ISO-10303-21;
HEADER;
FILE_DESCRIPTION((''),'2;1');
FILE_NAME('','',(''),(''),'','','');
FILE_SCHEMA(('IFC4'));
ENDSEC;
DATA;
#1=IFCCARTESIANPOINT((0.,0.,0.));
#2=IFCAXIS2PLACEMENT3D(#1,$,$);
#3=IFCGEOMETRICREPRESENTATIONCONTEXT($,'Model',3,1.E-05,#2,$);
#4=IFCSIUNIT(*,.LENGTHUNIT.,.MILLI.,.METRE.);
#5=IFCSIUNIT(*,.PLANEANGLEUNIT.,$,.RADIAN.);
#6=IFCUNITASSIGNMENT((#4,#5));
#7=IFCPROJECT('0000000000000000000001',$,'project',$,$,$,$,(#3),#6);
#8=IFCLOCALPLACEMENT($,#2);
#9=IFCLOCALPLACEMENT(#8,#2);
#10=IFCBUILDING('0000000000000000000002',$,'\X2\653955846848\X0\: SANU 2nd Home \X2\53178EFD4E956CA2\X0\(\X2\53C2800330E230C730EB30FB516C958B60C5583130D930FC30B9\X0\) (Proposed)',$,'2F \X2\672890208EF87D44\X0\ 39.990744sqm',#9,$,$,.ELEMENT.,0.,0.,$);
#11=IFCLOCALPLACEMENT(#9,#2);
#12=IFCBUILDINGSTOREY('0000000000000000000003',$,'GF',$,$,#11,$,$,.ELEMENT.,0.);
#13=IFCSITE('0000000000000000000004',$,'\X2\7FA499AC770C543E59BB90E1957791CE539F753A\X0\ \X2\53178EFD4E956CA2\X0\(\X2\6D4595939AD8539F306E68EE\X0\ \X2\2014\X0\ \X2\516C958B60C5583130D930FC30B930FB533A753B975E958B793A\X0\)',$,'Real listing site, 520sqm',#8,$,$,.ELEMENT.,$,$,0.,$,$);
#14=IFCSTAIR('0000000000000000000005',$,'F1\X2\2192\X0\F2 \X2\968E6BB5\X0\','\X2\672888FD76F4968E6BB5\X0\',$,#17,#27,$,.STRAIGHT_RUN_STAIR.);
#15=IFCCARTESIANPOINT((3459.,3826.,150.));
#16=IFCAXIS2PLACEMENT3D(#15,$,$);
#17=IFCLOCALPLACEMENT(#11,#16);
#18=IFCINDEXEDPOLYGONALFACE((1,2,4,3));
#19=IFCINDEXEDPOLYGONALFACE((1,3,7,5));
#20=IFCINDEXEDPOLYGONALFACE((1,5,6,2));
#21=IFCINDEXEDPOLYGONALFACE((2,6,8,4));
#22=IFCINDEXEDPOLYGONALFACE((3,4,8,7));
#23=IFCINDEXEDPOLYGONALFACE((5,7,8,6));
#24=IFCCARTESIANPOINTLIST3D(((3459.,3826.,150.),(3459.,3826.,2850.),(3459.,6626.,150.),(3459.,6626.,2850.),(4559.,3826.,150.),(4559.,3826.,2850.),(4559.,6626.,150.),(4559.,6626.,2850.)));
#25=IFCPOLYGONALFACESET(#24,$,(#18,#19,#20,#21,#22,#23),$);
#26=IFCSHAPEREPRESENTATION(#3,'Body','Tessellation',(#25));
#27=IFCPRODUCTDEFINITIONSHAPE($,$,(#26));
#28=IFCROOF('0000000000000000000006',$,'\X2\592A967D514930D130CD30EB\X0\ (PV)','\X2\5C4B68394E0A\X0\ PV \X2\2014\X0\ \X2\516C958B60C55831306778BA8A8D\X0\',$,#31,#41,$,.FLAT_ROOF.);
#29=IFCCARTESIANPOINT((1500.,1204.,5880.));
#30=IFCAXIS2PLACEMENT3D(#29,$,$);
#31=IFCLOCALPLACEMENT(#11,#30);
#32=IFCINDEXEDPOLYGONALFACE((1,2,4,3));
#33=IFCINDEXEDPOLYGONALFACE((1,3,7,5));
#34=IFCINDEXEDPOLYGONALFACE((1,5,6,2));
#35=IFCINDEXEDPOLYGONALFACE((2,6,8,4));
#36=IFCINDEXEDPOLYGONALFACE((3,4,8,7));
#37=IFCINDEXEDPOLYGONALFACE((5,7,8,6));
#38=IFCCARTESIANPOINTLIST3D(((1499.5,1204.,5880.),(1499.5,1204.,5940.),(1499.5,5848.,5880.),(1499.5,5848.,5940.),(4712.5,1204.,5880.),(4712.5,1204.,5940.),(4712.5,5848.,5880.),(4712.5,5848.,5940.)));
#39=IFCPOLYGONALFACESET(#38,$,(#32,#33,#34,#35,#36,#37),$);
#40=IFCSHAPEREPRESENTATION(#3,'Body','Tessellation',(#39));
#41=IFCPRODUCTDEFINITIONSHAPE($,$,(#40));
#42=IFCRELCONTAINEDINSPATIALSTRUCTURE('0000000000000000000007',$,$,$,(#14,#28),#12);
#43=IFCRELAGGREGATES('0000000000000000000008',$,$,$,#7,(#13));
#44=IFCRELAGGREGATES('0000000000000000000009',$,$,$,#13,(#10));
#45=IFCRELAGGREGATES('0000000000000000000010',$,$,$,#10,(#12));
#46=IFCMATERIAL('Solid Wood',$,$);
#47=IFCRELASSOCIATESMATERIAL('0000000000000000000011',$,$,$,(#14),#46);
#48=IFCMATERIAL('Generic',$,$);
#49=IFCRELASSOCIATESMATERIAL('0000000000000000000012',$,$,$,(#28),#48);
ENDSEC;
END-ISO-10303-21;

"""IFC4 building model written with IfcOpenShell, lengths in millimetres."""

from ifc_helpers import new_model, si_unit, frame, frame_2d, origin, place, context, project, spatial, rectangle, extrude, material, element, save


model = new_model("IFC4")

# Units and contexts
model_context = context("Model", 3, precision=1e-05, world=origin())
ifc_project = project(units=[si_unit("LENGTHUNIT", "METRE", prefix="MILLI"), si_unit("PLANEANGLEUNIT", "RADIAN")], contexts=[model_context])

# Site, building, storey
site_placement = place(None, origin())
site = spatial("IfcSite", under=ifc_project, at=site_placement, Name="群馬県吾妻郡長野原町 北軽井沢(浅間高原の森 — 公開情報ベース・区画非開示)", ObjectType="Real listing site, 520sqm", CompositionType="ELEMENT", RefElevation=0.0)
building_placement = place(site_placement, origin())
building = spatial("IfcBuilding", under=site, at=building_placement, Name="改善案: SANU 2nd Home 北軽井沢(参考モデル・公開情報ベース) (Proposed)", ObjectType="2F 木造軸組 39.990744sqm", CompositionType="ELEMENT", ElevationOfRefHeight=0.0, ElevationOfTerrain=0.0)
storey_placement = place(building_placement, origin())
storey = spatial("IfcBuildingStorey", under=building, at=storey_placement, Name="GF", CompositionType="ELEMENT", Elevation=0.0)

# Shared definitions
ifc_material_1 = material(Name="Generic")

# Stair
ifc_material_2 = material(Name="Solid Wood")
stair_placement = place(storey_placement, frame((3459.0, 3826.0, 150.0)))
element("IfcStair", 1, at=stair_placement, inside=storey, material=ifc_material_2, Name="F1→F2 階段", Description="木製直階段", PredefinedType="STRAIGHT_RUN_STAIR", context=model_context, shape_type="SweptSolid", body=[
    extrude(rectangle(XDim=1100.0, YDim=2800.0, at=frame_2d((550.0, 1400.0))), frame((3459.0, 3826.0, 150.0)), (0.0, 0.0, 1.0), 2700.0),
])

# Roof
roof_placement = place(storey_placement, frame((1500.0, 1204.0, 5880.0)))
element("IfcRoof", 2, at=roof_placement, inside=storey, material=ifc_material_1, Name="太陽光パネル (PV)", Description="屋根上 PV — 公開情報で確認", PredefinedType="FLAT_ROOF", context=model_context, shape_type="SweptSolid", body=[
    extrude(rectangle(XDim=3213.0, YDim=4644.0, at=frame_2d((1606.0, 2322.0))), frame((1500.0, 1204.0, 5880.0)), (0.0, 0.0, 1.0), 60.0),
])

save(model, "model.ifc")
